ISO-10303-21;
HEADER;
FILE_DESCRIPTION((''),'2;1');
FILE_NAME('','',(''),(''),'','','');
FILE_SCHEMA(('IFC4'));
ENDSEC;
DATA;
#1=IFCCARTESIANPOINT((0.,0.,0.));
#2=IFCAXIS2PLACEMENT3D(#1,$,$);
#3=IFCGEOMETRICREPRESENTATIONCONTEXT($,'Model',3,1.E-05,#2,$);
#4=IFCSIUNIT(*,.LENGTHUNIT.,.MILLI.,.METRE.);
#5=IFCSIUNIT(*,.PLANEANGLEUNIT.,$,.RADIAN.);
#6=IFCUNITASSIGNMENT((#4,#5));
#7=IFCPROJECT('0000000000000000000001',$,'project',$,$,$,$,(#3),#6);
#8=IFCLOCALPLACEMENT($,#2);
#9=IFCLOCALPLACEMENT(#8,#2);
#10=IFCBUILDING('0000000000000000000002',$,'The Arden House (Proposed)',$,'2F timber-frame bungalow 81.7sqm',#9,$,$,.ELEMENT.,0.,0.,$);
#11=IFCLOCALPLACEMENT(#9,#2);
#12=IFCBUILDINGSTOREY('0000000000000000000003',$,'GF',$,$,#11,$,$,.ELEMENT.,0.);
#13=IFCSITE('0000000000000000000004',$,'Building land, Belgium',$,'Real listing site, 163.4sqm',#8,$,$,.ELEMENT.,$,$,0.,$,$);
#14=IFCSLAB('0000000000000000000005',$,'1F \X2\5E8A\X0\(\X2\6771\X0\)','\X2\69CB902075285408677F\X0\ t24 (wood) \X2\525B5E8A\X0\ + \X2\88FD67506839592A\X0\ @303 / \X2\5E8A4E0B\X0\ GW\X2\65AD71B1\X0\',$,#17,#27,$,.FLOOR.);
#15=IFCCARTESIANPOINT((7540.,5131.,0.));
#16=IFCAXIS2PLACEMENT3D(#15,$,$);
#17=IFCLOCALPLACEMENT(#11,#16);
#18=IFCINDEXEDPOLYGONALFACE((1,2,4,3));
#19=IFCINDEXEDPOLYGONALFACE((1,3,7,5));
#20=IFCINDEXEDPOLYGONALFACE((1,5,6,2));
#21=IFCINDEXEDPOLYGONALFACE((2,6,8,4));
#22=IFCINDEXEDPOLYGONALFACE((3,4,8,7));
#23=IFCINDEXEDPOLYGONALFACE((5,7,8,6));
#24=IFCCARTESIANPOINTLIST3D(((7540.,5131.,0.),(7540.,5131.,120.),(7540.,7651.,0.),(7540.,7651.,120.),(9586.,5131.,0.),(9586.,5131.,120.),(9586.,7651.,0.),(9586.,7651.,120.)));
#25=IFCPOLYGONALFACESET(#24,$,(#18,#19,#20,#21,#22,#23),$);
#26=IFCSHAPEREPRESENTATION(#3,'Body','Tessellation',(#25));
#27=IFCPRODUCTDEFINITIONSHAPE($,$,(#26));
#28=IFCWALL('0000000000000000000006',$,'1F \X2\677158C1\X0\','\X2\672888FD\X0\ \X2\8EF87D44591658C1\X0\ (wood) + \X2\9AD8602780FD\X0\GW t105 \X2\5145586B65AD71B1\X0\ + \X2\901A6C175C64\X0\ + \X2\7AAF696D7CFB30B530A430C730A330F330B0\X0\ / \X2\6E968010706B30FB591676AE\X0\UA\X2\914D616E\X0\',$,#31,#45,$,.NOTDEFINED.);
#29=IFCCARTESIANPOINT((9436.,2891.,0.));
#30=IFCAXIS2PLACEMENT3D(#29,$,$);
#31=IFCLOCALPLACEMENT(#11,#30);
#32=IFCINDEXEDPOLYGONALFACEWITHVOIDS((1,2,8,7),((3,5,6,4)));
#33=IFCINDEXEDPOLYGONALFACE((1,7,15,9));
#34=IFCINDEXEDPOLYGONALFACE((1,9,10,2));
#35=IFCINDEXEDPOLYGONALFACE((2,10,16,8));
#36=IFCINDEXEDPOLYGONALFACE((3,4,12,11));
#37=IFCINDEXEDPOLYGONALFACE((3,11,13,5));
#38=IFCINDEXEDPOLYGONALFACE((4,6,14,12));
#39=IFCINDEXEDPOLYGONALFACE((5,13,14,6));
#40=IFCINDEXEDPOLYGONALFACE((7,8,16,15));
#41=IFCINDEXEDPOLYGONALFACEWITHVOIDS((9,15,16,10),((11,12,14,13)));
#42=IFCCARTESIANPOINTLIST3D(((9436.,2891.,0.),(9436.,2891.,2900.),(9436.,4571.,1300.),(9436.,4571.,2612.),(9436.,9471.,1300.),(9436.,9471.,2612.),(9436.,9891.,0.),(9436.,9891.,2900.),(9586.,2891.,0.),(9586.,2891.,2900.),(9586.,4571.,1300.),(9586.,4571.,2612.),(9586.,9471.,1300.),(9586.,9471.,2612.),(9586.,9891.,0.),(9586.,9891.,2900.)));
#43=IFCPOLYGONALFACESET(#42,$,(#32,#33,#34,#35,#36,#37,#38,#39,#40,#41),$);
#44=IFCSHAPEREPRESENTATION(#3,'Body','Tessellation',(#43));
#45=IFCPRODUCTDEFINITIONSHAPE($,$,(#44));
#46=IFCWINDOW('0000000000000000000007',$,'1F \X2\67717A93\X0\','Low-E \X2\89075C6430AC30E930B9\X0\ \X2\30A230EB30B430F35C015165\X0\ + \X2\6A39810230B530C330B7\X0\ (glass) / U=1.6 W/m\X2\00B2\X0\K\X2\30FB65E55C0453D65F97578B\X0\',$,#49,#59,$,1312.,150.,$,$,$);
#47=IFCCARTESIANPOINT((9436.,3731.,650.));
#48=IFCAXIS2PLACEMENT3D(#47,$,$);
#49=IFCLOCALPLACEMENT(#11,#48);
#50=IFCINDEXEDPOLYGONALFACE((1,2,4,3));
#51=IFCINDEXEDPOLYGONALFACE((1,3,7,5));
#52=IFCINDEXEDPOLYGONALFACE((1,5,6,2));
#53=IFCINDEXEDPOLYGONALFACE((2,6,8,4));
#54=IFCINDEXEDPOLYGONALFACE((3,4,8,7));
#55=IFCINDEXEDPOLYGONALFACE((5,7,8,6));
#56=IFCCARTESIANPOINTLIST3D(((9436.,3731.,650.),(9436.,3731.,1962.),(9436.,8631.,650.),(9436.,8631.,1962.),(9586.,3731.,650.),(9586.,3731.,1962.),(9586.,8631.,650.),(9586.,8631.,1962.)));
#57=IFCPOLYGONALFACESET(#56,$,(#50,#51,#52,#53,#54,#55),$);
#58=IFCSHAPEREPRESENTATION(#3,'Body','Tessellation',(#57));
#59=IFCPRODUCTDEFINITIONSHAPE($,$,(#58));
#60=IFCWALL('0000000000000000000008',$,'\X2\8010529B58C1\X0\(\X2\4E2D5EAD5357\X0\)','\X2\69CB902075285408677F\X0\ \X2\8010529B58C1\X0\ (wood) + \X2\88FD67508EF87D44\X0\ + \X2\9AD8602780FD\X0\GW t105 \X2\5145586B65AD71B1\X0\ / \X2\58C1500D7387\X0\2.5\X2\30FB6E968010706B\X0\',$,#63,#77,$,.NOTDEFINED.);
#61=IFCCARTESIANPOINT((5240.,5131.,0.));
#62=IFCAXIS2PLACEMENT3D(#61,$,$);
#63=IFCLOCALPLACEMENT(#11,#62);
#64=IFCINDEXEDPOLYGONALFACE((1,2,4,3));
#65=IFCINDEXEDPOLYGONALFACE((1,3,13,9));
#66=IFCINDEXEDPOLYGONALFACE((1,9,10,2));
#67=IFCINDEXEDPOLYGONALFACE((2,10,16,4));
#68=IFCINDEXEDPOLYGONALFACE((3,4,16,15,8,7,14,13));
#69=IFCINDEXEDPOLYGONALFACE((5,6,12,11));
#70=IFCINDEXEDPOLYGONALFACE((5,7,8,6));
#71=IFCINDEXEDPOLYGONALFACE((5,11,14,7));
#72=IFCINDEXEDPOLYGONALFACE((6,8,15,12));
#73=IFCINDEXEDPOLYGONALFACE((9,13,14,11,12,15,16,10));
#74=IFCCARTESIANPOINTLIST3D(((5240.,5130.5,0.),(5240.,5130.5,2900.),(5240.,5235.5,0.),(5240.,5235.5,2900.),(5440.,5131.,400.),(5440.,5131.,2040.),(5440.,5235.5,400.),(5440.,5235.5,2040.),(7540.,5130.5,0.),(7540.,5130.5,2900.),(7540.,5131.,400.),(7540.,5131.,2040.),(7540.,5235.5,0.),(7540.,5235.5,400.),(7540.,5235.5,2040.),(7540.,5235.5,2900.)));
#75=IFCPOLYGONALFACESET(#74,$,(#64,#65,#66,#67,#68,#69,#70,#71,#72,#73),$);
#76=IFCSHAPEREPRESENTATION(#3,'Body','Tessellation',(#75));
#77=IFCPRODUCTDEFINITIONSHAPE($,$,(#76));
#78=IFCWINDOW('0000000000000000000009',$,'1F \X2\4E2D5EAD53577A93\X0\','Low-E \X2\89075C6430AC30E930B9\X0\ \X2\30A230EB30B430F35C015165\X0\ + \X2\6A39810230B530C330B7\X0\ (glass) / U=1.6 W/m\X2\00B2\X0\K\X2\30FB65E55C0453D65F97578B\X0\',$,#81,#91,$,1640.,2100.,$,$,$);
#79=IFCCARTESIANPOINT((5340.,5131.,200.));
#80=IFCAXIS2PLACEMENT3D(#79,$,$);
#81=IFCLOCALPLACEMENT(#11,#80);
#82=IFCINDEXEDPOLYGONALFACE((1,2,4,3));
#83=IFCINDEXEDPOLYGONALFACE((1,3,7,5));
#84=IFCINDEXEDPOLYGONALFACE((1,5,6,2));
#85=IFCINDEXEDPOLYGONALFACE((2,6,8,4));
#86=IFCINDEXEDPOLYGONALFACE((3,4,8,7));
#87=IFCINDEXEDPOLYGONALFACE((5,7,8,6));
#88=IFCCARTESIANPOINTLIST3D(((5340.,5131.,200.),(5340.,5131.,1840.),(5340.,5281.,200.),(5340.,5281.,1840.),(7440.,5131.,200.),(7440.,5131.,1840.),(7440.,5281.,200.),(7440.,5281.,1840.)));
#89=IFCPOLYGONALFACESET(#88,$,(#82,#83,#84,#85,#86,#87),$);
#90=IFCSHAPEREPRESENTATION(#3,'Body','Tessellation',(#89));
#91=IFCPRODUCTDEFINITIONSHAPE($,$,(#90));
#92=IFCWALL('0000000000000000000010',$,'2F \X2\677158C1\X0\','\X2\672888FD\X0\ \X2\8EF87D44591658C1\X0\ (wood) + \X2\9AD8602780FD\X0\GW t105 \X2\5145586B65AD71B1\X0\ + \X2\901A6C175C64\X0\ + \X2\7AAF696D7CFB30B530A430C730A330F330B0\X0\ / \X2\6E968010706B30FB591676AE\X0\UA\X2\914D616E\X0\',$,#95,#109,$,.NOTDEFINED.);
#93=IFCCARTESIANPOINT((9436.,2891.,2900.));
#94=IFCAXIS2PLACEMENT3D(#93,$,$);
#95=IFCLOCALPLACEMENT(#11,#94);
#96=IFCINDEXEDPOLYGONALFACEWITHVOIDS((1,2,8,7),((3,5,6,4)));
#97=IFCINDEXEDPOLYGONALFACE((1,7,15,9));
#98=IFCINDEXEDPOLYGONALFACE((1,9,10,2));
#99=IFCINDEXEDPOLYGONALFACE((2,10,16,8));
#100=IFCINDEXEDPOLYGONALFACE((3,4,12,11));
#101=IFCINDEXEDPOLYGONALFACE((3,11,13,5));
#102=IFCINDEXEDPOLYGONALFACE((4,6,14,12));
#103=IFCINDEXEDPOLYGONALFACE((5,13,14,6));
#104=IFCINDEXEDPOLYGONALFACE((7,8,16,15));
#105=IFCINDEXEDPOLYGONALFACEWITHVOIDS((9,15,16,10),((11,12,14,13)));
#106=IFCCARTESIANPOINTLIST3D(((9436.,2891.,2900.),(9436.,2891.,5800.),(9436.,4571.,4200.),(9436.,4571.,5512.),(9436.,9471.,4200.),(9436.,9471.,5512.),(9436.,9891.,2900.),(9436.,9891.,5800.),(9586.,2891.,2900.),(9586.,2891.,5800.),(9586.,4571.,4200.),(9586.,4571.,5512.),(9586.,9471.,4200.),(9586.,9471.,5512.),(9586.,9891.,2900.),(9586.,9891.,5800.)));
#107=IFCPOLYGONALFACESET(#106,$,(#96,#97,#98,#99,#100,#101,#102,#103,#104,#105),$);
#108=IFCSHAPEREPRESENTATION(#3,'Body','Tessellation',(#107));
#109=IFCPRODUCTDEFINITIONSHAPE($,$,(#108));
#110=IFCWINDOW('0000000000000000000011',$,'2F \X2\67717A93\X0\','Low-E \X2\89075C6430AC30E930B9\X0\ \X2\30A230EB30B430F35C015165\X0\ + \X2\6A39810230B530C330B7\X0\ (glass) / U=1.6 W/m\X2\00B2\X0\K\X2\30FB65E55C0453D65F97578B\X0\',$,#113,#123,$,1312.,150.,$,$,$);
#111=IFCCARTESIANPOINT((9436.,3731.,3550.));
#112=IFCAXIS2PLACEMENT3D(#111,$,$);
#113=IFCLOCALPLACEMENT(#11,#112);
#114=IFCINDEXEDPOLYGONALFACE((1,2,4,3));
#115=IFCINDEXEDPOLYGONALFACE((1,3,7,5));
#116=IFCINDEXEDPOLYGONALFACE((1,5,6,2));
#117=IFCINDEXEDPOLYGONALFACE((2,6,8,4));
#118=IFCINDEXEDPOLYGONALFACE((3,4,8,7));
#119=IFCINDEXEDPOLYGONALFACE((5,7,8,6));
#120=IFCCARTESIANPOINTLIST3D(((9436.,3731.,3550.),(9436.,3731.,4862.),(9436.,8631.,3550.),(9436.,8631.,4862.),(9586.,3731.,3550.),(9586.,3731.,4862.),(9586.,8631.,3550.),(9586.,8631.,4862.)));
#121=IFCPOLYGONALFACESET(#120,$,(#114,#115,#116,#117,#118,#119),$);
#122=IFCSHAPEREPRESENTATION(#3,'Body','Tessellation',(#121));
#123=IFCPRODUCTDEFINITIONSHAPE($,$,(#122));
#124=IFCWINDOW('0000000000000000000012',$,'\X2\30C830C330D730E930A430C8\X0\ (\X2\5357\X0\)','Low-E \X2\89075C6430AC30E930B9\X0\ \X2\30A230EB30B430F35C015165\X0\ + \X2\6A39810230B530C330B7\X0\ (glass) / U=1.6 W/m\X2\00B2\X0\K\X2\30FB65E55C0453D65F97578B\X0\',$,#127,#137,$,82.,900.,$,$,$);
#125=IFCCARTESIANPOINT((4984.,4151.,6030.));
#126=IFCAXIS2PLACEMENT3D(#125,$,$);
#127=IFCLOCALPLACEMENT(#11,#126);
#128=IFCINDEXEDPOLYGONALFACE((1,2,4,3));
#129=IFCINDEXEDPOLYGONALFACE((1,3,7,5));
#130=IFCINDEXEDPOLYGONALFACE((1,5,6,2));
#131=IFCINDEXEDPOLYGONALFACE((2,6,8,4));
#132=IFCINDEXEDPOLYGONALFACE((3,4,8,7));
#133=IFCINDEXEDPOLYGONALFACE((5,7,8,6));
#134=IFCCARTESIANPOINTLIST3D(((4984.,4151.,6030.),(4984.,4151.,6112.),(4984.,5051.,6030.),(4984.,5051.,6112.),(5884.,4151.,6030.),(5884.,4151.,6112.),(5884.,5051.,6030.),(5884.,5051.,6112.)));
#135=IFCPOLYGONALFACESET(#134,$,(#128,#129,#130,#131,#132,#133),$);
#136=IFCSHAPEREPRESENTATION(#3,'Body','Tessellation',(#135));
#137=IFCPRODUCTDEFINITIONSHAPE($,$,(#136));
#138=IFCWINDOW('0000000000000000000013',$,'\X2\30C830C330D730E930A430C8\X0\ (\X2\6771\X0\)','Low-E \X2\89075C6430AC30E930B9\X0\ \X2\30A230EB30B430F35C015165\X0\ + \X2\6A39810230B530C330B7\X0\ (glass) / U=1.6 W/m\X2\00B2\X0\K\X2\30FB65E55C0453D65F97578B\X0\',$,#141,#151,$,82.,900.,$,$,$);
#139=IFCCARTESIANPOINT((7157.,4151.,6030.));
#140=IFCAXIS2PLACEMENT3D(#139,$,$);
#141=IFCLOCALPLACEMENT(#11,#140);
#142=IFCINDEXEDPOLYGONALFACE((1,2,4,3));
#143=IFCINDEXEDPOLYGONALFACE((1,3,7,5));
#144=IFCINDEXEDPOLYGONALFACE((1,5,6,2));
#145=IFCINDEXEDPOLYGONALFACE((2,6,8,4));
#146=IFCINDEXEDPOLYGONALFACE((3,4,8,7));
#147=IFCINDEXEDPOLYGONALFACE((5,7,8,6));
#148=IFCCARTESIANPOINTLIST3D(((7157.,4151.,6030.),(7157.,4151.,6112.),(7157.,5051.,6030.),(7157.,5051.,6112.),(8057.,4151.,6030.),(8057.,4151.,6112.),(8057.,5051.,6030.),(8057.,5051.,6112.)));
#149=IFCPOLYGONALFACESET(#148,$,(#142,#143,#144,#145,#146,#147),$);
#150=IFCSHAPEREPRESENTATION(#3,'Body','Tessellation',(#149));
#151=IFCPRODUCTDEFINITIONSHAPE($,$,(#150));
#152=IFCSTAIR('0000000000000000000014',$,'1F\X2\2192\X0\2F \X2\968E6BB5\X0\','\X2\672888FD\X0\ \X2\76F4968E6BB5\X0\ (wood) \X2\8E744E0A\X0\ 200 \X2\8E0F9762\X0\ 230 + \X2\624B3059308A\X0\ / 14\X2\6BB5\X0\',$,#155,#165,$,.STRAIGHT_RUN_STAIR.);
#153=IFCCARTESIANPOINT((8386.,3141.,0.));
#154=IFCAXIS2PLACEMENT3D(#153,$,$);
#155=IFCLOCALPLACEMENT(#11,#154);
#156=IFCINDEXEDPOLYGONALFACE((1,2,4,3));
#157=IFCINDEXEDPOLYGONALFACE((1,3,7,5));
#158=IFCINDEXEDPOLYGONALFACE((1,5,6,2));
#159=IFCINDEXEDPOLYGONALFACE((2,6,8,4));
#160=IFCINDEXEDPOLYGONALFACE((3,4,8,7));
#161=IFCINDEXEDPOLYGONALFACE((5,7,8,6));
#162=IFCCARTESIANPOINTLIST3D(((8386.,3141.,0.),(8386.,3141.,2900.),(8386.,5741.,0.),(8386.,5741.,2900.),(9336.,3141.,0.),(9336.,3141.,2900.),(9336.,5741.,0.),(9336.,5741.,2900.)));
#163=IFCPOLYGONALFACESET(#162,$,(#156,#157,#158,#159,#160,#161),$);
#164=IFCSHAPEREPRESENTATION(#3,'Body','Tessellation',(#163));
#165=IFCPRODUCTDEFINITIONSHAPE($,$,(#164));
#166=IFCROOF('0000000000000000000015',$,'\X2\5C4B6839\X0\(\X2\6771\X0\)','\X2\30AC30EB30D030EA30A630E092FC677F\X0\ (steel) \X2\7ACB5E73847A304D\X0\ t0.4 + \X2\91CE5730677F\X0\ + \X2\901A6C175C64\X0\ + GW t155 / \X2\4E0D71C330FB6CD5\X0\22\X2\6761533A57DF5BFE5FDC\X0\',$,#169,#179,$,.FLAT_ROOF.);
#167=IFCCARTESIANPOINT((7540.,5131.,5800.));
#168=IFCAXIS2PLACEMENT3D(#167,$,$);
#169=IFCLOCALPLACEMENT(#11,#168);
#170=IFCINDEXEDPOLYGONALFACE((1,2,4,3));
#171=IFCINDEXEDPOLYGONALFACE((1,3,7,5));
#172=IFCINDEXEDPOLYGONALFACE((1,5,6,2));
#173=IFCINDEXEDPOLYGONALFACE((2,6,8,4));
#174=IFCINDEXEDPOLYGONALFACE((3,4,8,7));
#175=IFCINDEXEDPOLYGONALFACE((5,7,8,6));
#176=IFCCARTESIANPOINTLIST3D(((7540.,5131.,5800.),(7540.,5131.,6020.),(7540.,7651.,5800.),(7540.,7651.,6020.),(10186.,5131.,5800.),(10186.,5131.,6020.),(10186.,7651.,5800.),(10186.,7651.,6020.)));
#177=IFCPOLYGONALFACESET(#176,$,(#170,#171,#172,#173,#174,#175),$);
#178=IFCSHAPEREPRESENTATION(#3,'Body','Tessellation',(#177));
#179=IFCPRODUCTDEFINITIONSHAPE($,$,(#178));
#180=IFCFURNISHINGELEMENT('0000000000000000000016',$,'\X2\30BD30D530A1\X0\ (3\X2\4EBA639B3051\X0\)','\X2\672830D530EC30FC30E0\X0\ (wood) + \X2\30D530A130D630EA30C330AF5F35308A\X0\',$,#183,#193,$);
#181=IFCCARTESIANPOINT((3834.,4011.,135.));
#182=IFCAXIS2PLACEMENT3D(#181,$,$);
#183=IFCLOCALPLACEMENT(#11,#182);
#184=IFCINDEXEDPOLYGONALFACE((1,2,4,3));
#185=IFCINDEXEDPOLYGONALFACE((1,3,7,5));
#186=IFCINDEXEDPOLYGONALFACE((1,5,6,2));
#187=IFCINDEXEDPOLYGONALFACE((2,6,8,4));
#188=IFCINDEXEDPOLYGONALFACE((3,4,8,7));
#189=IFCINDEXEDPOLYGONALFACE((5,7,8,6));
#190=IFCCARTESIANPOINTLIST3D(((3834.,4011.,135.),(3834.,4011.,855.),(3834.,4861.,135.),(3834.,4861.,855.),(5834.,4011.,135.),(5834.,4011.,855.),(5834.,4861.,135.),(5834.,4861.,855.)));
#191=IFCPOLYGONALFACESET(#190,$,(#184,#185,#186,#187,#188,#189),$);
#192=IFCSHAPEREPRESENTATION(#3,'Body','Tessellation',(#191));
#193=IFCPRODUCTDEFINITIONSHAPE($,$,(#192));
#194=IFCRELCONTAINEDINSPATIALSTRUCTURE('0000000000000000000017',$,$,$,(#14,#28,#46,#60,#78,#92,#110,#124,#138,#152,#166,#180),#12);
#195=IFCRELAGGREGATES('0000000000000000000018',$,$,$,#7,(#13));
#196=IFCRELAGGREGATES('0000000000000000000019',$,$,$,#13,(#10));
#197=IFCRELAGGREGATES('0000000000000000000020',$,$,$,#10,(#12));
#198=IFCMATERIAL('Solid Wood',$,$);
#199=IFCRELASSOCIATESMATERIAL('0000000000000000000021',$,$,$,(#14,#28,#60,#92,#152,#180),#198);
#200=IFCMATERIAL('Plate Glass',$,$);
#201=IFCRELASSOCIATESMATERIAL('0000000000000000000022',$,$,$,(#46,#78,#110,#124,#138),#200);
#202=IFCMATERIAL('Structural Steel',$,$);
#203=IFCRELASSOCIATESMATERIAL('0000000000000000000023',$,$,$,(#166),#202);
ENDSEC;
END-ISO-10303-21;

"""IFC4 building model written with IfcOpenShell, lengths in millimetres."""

from ifc_helpers import new_model, si_unit, frame, frame_2d, origin, place, context, project, spatial, rectangle, extrude, material, element, fill, save


model = new_model("IFC4")

# Units and contexts
model_context = context("Model", 3, precision=1e-05, world=origin())
ifc_project = project(units=[si_unit("LENGTHUNIT", "METRE", prefix="MILLI"), si_unit("PLANEANGLEUNIT", "RADIAN")], contexts=[model_context])

# Site, building, storey
site_placement = place(None, origin())
site = spatial("IfcSite", under=ifc_project, at=site_placement, Name="Building land, Belgium", ObjectType="Real listing site, 163.4sqm", CompositionType="ELEMENT", RefElevation=0.0)
building_placement = place(site_placement, origin())
building = spatial("IfcBuilding", under=site, at=building_placement, Name="The Arden House (Proposed)", ObjectType="2F timber-frame bungalow 81.7sqm", CompositionType="ELEMENT", ElevationOfRefHeight=0.0, ElevationOfTerrain=0.0)
storey_placement = place(building_placement, origin())
storey = spatial("IfcBuildingStorey", under=building, at=storey_placement, Name="GF", CompositionType="ELEMENT", Elevation=0.0)

# Slab
ifc_material_1 = material(Name="Solid Wood")
slab_placement = place(storey_placement, frame((7540.0, 5131.0, 0.0)))
element("IfcSlab", 1, at=slab_placement, inside=storey, material=ifc_material_1, Name="1F 床(東)", Description="構造用合板 t24 (wood) 剛床 + 製材根太 @303 / 床下 GW断熱", PredefinedType="FLOOR", context=model_context, shape_type="SweptSolid", body=[
    extrude(rectangle(XDim=2046.0, YDim=2520.0, at=frame_2d((1023.0, 1260.0))), frame((7540.0, 5131.0, 0.0)), (0.0, 0.0, 1.0), 120.0),
])

# Walls, openings, windows
wall_1_placement = place(storey_placement, frame((9436.0, 2891.0, 0.0)))
wall_1 = element("IfcWall", 2, at=wall_1_placement, inside=storey, material=ifc_material_1, Name="1F 東壁", Description="木製 軸組外壁 (wood) + 高性能GW t105 充填断熱 + 通気層 + 窯業系サイディング / 準耐火・外皮UA配慮", PredefinedType="NOTDEFINED", context=model_context, shape_type="SweptSolid", body=[
    extrude(rectangle(XDim=150.0, YDim=7000.0, at=frame_2d((75.0, 3500.0))), frame((9436.0, 2891.0, 0.0)), (0.0, 0.0, 1.0), 2900.0),
])
opening_1_placement = place(storey_placement, frame((9436.0, 3731.0, 650.0)))
opening_1 = element("IfcOpeningElement", 3, at=opening_1_placement, cuts=wall_1, PredefinedType="NOTDEFINED", context=model_context, shape_type="SweptSolid", body=[
    extrude(rectangle(XDim=150.0, YDim=4900.0, at=frame_2d((75.0, 2450.0))), frame((9436.0, 3731.0, 650.0)), (0.0, 0.0, 1.0), 1312.0),
])
ifc_material_2 = material(Name="Plate Glass")
window_1_placement = place(storey_placement, frame((9436.0, 3731.0, 650.0)))
window_1 = element("IfcWindow", 4, at=window_1_placement, inside=storey, material=ifc_material_2, Name="1F 東窓", Description="Low-E 複層ガラス アルゴン封入 + 樹脂サッシ (glass) / U=1.6 W/m²K・日射取得型", OverallHeight=1312.0, OverallWidth=150.0, context=model_context, shape_type="SweptSolid", body=[
    extrude(rectangle(XDim=150.0, YDim=4900.0, at=frame_2d((75.0, 2450.0))), frame((9436.0, 3731.0, 650.0)), (0.0, 0.0, 1.0), 1312.0),
])
fill(opening_1, window_1)
wall_2_placement = place(storey_placement, frame((5240.0, 5131.0, 0.0)))
wall_2 = element("IfcWall", 5, at=wall_2_placement, inside=storey, material=ifc_material_1, Name="耐力壁(中庭南)", Description="構造用合板 耐力壁 (wood) + 製材軸組 + 高性能GW t105 充填断熱 / 壁倍率2.5・準耐火", PredefinedType="NOTDEFINED", context=model_context, shape_type="SweptSolid", body=[
    extrude(rectangle(XDim=2300.0, YDim=105.0, at=frame_2d((1150.0, 52.0))), frame((5240.0, 5131.0, 0.0)), (0.0, 0.0, 1.0), 2900.0),
])
opening_2_placement = place(storey_placement, frame((5340.0, 5131.0, 200.0)))
opening_2 = element("IfcOpeningElement", 6, at=opening_2_placement, cuts=wall_2, PredefinedType="NOTDEFINED", context=model_context, shape_type="SweptSolid", body=[
    extrude(rectangle(XDim=2100.0, YDim=150.0, at=frame_2d((1050.0, 75.0))), frame((5340.0, 5131.0, 200.0)), (0.0, 0.0, 1.0), 1640.0),
])
window_2_placement = place(storey_placement, frame((5340.0, 5131.0, 200.0)))
window_2 = element("IfcWindow", 7, at=window_2_placement, inside=storey, material=ifc_material_2, Name="1F 中庭南窓", Description="Low-E 複層ガラス アルゴン封入 + 樹脂サッシ (glass) / U=1.6 W/m²K・日射取得型", OverallHeight=1640.0, OverallWidth=2100.0, context=model_context, shape_type="SweptSolid", body=[
    extrude(rectangle(XDim=2100.0, YDim=150.0, at=frame_2d((1050.0, 75.0))), frame((5340.0, 5131.0, 200.0)), (0.0, 0.0, 1.0), 1640.0),
])
fill(opening_2, window_2)

# Wall, opening, window
wall_3_placement = place(storey_placement, frame((9436.0, 2891.0, 2900.0)))
wall_3 = element("IfcWall", 8, at=wall_3_placement, inside=storey, material=ifc_material_1, Name="2F 東壁", Description="木製 軸組外壁 (wood) + 高性能GW t105 充填断熱 + 通気層 + 窯業系サイディング / 準耐火・外皮UA配慮", PredefinedType="NOTDEFINED", context=model_context, shape_type="SweptSolid", body=[
    extrude(rectangle(XDim=150.0, YDim=7000.0, at=frame_2d((75.0, 3500.0))), frame((9436.0, 2891.0, 2900.0)), (0.0, 0.0, 1.0), 2900.0),
])
opening_3_placement = place(storey_placement, frame((9436.0, 3731.0, 3550.0)))
opening_3 = element("IfcOpeningElement", 9, at=opening_3_placement, cuts=wall_3, PredefinedType="NOTDEFINED", context=model_context, shape_type="SweptSolid", body=[
    extrude(rectangle(XDim=150.0, YDim=4900.0, at=frame_2d((75.0, 2450.0))), frame((9436.0, 3731.0, 3550.0)), (0.0, 0.0, 1.0), 1312.0),
])
window_3_placement = place(storey_placement, frame((9436.0, 3731.0, 3550.0)))
window_3 = element("IfcWindow", 10, at=window_3_placement, inside=storey, material=ifc_material_2, Name="2F 東窓", Description="Low-E 複層ガラス アルゴン封入 + 樹脂サッシ (glass) / U=1.6 W/m²K・日射取得型", OverallHeight=1312.0, OverallWidth=150.0, context=model_context, shape_type="SweptSolid", body=[
    extrude(rectangle(XDim=150.0, YDim=4900.0, at=frame_2d((75.0, 2450.0))), frame((9436.0, 3731.0, 3550.0)), (0.0, 0.0, 1.0), 1312.0),
])
fill(opening_3, window_3)

# Windows
window_4_placement = place(storey_placement, frame((4984.0, 4151.0, 6030.0)))
element("IfcWindow", 11, at=window_4_placement, inside=storey, material=ifc_material_2, Name="トップライト (南)", Description="Low-E 複層ガラス アルゴン封入 + 樹脂サッシ (glass) / U=1.6 W/m²K・日射取得型", OverallHeight=82.0, OverallWidth=900.0, context=model_context, shape_type="SweptSolid", body=[
    extrude(rectangle(XDim=900.0, YDim=900.0, at=frame_2d((450.0, 450.0))), frame((4984.0, 4151.0, 6030.0)), (0.0, 0.0, 1.0), 82.0),
])
window_5_placement = place(storey_placement, frame((7157.0, 4151.0, 6030.0)))
element("IfcWindow", 12, at=window_5_placement, inside=storey, material=ifc_material_2, Name="トップライト (東)", Description="Low-E 複層ガラス アルゴン封入 + 樹脂サッシ (glass) / U=1.6 W/m²K・日射取得型", OverallHeight=82.0, OverallWidth=900.0, context=model_context, shape_type="SweptSolid", body=[
    extrude(rectangle(XDim=900.0, YDim=900.0, at=frame_2d((450.0, 450.0))), frame((7157.0, 4151.0, 6030.0)), (0.0, 0.0, 1.0), 82.0),
])

# Stair
stair_placement = place(storey_placement, frame((8386.0, 3141.0, 0.0)))
element("IfcStair", 13, at=stair_placement, inside=storey, material=ifc_material_1, Name="1F→2F 階段", Description="木製 直階段 (wood) 蹴上 200 踏面 230 + 手すり / 14段", PredefinedType="STRAIGHT_RUN_STAIR", context=model_context, shape_type="SweptSolid", body=[
    extrude(rectangle(XDim=950.0, YDim=2600.0, at=frame_2d((475.0, 1300.0))), frame((8386.0, 3141.0, 0.0)), (0.0, 0.0, 1.0), 2900.0),
])

# Roof
ifc_material_3 = material(Name="Structural Steel")
roof_placement = place(storey_placement, frame((7540.0, 5131.0, 5800.0)))
element("IfcRoof", 14, at=roof_placement, inside=storey, material=ifc_material_3, Name="屋根(東)", Description="ガルバリウム鋼板 (steel) 立平葺き t0.4 + 野地板 + 通気層 + GW t155 / 不燃・法22条区域対応", PredefinedType="FLAT_ROOF", context=model_context, shape_type="SweptSolid", body=[
    extrude(rectangle(XDim=2646.0, YDim=2520.0, at=frame_2d((1323.0, 1260.0))), frame((7540.0, 5131.0, 5800.0)), (0.0, 0.0, 1.0), 220.0),
])

# Furnishing element
furnishing_1_placement = place(storey_placement, frame((3834.0, 4011.0, 135.0)))
element("IfcFurnishingElement", 15, at=furnishing_1_placement, inside=storey, material=ifc_material_1, Name="ソファ (3人掛け)", Description="木フレーム (wood) + ファブリック張り", context=model_context, shape_type="SweptSolid", body=[
    extrude(rectangle(XDim=2000.0, YDim=850.0, at=frame_2d((1000.0, 425.0))), frame((3834.0, 4011.0, 135.0)), (0.0, 0.0, 1.0), 720.0),
])

save(model, "model.ifc")
